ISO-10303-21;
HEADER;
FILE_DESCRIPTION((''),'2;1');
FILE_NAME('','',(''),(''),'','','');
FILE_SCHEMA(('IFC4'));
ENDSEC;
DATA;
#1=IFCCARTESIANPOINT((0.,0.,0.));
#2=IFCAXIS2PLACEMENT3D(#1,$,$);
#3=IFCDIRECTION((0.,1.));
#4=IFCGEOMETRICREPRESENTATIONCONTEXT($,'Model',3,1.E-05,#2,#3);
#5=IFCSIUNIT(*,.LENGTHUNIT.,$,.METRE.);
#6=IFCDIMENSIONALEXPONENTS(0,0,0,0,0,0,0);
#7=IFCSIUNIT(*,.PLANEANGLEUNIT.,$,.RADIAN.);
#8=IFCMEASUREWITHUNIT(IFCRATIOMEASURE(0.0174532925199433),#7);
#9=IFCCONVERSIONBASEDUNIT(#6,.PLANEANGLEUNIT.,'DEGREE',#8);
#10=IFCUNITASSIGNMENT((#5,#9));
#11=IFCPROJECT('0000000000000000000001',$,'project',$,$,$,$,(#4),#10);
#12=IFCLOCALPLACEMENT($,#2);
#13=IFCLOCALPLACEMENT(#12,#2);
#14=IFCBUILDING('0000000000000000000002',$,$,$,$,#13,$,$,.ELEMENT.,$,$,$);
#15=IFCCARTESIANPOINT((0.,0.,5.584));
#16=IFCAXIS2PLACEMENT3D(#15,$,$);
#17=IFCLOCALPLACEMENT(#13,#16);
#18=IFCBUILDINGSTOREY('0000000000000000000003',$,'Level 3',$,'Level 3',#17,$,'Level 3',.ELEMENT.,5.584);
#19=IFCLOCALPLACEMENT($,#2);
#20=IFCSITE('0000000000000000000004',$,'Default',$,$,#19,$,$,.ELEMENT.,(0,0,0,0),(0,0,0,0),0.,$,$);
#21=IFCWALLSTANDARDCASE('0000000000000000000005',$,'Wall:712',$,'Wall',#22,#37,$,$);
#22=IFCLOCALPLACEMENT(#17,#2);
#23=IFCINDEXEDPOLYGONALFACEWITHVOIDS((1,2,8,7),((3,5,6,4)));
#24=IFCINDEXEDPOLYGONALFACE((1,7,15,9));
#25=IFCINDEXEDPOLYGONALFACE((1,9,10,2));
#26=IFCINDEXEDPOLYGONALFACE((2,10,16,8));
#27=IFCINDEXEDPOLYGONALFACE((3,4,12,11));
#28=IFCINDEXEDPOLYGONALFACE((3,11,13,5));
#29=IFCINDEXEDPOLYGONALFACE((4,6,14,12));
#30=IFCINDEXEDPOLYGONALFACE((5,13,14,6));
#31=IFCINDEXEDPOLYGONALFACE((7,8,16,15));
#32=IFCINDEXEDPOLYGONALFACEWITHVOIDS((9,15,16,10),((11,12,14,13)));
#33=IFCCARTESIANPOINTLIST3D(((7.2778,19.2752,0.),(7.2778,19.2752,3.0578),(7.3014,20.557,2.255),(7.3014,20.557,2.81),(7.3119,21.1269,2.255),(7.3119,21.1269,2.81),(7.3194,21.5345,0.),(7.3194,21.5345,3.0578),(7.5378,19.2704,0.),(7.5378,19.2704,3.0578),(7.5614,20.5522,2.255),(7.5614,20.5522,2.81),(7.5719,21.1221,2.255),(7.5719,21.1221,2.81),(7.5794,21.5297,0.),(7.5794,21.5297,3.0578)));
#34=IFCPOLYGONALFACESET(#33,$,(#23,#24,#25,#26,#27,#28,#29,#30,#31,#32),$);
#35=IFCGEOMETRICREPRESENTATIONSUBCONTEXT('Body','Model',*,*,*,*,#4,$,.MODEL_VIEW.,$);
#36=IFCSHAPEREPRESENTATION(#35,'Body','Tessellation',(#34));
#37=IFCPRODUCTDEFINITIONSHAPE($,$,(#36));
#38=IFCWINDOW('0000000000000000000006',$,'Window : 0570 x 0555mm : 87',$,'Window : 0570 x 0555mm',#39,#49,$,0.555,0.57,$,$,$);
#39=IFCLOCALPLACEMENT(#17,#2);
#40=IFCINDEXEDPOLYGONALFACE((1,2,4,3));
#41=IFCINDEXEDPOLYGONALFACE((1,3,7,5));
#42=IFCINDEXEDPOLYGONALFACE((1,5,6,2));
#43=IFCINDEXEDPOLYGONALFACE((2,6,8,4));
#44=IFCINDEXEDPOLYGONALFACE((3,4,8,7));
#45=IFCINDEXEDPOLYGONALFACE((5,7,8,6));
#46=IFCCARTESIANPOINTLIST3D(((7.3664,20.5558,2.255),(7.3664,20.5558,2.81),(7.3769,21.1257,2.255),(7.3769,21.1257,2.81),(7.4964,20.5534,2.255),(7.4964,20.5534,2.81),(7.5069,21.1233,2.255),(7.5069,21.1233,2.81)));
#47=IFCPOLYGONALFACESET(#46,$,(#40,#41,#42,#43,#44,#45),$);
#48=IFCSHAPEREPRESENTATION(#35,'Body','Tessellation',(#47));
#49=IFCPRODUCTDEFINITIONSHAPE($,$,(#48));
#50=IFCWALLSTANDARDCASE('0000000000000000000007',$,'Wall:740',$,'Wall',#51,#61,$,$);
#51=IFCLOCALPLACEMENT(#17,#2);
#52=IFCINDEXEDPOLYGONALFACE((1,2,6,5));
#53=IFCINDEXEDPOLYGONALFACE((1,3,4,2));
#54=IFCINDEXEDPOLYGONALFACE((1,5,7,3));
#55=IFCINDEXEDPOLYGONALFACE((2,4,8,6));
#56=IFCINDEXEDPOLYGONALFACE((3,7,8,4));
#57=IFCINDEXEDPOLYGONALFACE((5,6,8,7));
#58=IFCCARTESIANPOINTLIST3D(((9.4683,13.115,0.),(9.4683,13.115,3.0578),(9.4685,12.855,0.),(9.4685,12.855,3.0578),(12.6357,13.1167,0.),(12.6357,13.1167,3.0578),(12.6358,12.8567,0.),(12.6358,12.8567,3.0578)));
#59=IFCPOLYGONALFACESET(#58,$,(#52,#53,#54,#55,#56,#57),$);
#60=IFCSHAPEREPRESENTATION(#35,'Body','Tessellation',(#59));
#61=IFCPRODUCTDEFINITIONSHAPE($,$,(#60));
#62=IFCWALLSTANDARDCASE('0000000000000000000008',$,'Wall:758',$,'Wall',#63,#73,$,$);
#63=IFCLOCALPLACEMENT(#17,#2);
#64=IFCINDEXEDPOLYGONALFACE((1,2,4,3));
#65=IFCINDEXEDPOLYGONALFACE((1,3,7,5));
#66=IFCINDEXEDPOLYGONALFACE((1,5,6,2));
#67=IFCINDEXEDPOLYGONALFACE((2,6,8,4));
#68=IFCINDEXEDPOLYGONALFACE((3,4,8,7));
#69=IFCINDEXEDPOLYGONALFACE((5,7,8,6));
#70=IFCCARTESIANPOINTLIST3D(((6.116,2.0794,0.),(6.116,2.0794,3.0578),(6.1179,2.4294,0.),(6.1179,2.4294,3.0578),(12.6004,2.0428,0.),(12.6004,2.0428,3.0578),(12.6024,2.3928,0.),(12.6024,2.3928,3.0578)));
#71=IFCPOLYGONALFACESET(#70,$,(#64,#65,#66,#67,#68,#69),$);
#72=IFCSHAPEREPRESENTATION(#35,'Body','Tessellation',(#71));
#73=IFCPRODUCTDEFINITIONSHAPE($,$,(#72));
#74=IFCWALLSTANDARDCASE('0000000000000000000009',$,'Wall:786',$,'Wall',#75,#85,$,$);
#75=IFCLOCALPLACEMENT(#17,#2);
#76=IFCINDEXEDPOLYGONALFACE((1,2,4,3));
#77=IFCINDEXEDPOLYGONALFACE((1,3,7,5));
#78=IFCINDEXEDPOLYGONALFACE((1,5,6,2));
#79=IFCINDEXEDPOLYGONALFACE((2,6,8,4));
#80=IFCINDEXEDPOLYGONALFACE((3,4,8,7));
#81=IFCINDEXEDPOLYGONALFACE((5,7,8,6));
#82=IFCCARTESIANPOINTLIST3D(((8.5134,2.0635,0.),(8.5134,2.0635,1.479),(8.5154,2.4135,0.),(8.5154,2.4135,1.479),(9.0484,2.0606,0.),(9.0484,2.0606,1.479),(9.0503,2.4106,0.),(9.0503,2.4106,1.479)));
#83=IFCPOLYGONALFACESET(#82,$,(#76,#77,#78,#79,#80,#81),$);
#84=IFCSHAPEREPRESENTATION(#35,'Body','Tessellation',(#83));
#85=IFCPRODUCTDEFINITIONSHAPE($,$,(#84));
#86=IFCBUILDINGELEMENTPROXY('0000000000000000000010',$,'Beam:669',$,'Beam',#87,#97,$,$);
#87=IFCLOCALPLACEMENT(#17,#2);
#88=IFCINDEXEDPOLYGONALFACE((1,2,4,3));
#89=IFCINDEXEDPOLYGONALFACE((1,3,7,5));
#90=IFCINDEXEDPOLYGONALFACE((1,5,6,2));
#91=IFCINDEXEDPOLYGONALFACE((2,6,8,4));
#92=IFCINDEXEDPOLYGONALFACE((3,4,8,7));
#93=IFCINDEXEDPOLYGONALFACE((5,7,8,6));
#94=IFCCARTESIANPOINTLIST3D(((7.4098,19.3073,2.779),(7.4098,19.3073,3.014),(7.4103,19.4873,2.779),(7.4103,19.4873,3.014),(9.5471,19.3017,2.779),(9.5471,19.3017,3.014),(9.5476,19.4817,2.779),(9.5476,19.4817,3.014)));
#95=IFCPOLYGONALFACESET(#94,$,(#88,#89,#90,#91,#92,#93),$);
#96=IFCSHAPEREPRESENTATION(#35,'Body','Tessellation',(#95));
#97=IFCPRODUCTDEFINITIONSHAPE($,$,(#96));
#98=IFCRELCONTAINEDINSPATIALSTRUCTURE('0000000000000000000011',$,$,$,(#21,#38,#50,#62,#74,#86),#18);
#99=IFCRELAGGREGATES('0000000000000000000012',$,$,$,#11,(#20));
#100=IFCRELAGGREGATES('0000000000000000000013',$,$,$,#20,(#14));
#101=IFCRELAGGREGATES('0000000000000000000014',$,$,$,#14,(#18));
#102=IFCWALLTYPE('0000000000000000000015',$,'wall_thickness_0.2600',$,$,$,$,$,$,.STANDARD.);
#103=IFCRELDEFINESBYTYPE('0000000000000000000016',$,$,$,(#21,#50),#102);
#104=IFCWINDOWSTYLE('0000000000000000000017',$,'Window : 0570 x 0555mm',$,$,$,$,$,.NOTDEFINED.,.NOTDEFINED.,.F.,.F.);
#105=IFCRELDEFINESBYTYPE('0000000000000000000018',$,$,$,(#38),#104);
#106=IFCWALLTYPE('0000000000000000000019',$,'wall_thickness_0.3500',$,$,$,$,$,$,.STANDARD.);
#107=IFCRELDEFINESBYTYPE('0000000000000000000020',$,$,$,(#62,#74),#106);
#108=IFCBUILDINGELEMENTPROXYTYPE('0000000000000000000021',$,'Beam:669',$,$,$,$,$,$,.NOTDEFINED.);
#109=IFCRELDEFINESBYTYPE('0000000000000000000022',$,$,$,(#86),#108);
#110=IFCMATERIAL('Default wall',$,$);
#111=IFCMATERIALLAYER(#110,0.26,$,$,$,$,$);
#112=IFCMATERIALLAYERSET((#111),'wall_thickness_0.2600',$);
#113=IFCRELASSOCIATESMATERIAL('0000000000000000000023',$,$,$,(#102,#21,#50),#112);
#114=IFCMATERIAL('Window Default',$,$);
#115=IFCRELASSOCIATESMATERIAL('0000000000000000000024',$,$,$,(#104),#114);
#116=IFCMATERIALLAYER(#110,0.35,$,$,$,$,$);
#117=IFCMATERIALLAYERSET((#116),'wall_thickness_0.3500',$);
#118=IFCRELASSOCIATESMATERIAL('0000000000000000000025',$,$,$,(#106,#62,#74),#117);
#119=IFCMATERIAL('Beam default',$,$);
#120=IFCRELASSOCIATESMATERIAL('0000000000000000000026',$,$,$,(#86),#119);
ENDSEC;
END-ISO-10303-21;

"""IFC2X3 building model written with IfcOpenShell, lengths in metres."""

from ifc_helpers import new_model, entity, si_unit, converted_unit, direction, frame, frame_2d, origin, origin_2d_with_axis, place, context, subcontext, project, spatial, polyline, rectangle, outline, extrude, source, transform, mapped, material, layer, layer_set, layer_usage, type_object, type_shapes, element, fill, save


model = new_model("IFC2X3")

# Units and contexts
model_context = context("Model", 3, precision=1e-05, world=origin(), true_north=direction((0.0, 1.0)))
body_context = subcontext(model_context, "Body", "Model", "MODEL_VIEW")
ifc_project = project(units=[si_unit("LENGTHUNIT", "METRE"), converted_unit("PLANEANGLEUNIT", "DEGREE", entity("IfcRatioMeasure", 0.0174532925199433), si_unit("PLANEANGLEUNIT", "RADIAN"), dimensions=[0, 0, 0, 0, 0, 0, 0])], contexts=[model_context])

# Site, building, storey
site_placement = place(None, origin())
site = spatial("IfcSite", under=ifc_project, at=site_placement, Name="Default", CompositionType="ELEMENT", RefLatitude=(0, 0, 0, 0), RefLongitude=(0, 0, 0, 0), RefElevation=0.0)
placement_1 = place(None, origin())
building_placement = place(placement_1, origin())
building = spatial("IfcBuilding", under=site, at=building_placement, CompositionType="ELEMENT")
storey_placement = place(building_placement, frame((0.0, 0.0, 5.584)))
storey = spatial("IfcBuildingStorey", under=building, at=storey_placement, Name="Level 3", ObjectType="Level 3", LongName="Level 3", CompositionType="ELEMENT", Elevation=5.584)

# Shared definitions
ifc_material_1 = material(Name="Default wall")

# Shared definitions
ifc_layer_1 = layer(ifc_material_1, 0.26)
ifc_layer_set_1 = layer_set([ifc_layer_1], Name="wall_thickness_0.2600")
ifc_layer_usage_1 = layer_usage(ifc_layer_set_1, "AXIS2", "POSITIVE", -0.13)
wall_type_1 = type_object("IfcWallType", Name="wall_thickness_0.2600", PredefinedType="STANDARD", material=ifc_layer_set_1)

# Wall, opening, window
wall_1_placement = place(storey_placement, frame((7.4494, 21.5321, 0.0), z_axis=(0.0, 0.0, 1.0), x_axis=(-0.018413, -0.99983, 0.0)))
wall_1 = element("IfcWallStandardCase", 1, at=wall_1_placement, inside=storey, type_object=wall_type_1, material=ifc_layer_usage_1, Name="Wall:712", ObjectType="Wall", context=body_context, shape_type="SweptSolid", body=[
    extrude(outline(polyline([(2.2597, -0.13), (2.2597, 0.13), (0.0, 0.13), (0.0, -0.13), (2.2597, -0.13)])), origin(), (0.0, 0.0, 1.0), 3.0578),
])
opening_1_placement = place(wall_1_placement, frame((0.4077, -0.13, 2.255)))
opening_1 = element("IfcOpeningElement", 2, at=opening_1_placement, cuts=wall_1, ObjectType="Opening", context=body_context, shape_type="SweptSolid", body=[
    extrude(rectangle(XDim=0.57, YDim=0.555, at=frame_2d((0.2775, 0.285), x_axis=(0.0, 1.0))), frame((0.0, 0.0, 0.0), z_axis=(0.0, 1.0, 0.0), x_axis=(0.0, 0.0, 1.0)), (0.0, 0.0, 1.0), 0.26),
])
ifc_material_2 = material(Name="Window Default")
window_style = type_object("IfcWindowStyle", Name="Window : 0570 x 0555mm", ConstructionType="NOTDEFINED", OperationType="NOTDEFINED", ParameterTakesPrecedence=False, Sizeable=False, material=ifc_material_2)
shared_shape_1 = source(origin(), body_context, "Body", "SweptSolid", [
    extrude(rectangle(XDim=0.13, YDim=0.57, at=origin_2d_with_axis()), frame((0.285, 0.13, 0.0), z_axis=(0.0, 0.0, 1.0), x_axis=(0.0, 1.0, 0.0)), (0.0, 0.0, 1.0), 0.555),
])
type_shapes(window_style, [shared_shape_1])
window_placement = place(opening_1_placement, origin())
window = element("IfcWindow", 3, at=window_placement, inside=storey, type_object=window_style, Name="Window : 0570 x 0555mm : 87", ObjectType="Window : 0570 x 0555mm", OverallHeight=0.555, OverallWidth=0.57, context=body_context, shape_type="MappedRepresentation", body=[
    mapped(shared_shape_1, transform((0.0, 0.0, 0.0), scale=1.0)),
])
fill(opening_1, window)

# Walls
wall_2_placement = place(storey_placement, frame((9.4684, 12.985, 0.0), z_axis=(0.0, 0.0, 1.0), x_axis=(1.0, 0.000546, 0.0)))
element("IfcWallStandardCase", 4, at=wall_2_placement, inside=storey, type_object=wall_type_1, material=ifc_layer_usage_1, Name="Wall:740", ObjectType="Wall", context=body_context, shape_type="SweptSolid", body=[
    extrude(outline(polyline([(3.1673, -0.13), (3.1673, 0.13), (0.0, 0.13), (0.0, -0.13), (3.1673, -0.13)])), origin(), (0.0, 0.0, 1.0), 3.0578),
])
ifc_layer_2 = layer(ifc_material_1, 0.35)
ifc_layer_set_2 = layer_set([ifc_layer_2], Name="wall_thickness_0.3500")
ifc_layer_usage_2 = layer_usage(ifc_layer_set_2, "AXIS2", "POSITIVE", -0.175)
wall_type_2 = type_object("IfcWallType", Name="wall_thickness_0.3500", PredefinedType="STANDARD", material=ifc_layer_set_2)
wall_3_placement = place(storey_placement, frame((6.117, 2.2544, 0.0), z_axis=(0.0, 0.0, 1.0), x_axis=(0.999984, -0.005634, 0.0)))
element("IfcWallStandardCase", 5, at=wall_3_placement, inside=storey, type_object=wall_type_2, material=ifc_layer_usage_2, Name="Wall:758", ObjectType="Wall", context=body_context, shape_type="SweptSolid", body=[
    extrude(outline(polyline([(6.4846, -0.175), (6.4846, 0.175), (0.0, 0.175), (0.0, -0.175), (6.4846, -0.175)])), origin(), (0.0, 0.0, 1.0), 3.0578),
])
wall_4_placement = place(storey_placement, frame((8.5144, 2.2385, 0.0), z_axis=(0.0, 0.0, 1.0), x_axis=(0.999985, -0.005496, 0.0)))
element("IfcWallStandardCase", 6, at=wall_4_placement, inside=storey, type_object=wall_type_2, material=ifc_layer_usage_2, Name="Wall:786", ObjectType="Wall", context=body_context, shape_type="SweptSolid", body=[
    extrude(outline(polyline([(0.535, -0.175), (0.535, 0.175), (0.0, 0.175), (0.0, -0.175), (0.535, -0.175)])), origin(), (0.0, 0.0, 1.0), 1.479),
])

# Building element proxy
ifc_material_3 = material(Name="Beam default")
building_element_proxy_type = type_object("IfcBuildingElementProxyType", Name="Beam:669", PredefinedType="NOTDEFINED")
shared_shape_2 = source(origin(), body_context, "Body", "SweptSolid", [
    extrude(outline(polyline([(2.1373, -0.09), (2.1373, 0.09), (0.0, 0.09), (0.0, -0.09), (2.1373, -0.09)])), origin(), (0.0, 0.0, 1.0), 0.235),
])
type_shapes(building_element_proxy_type, [shared_shape_2])
placement_2 = place(building_placement, frame((0.0, 0.0, 8.363)))
proxy_placement = place(placement_2, frame((7.4101, 19.3973, 0.0), z_axis=(0.0, 0.0, 1.0), x_axis=(0.999996, -0.002646, 0.0)))
element("IfcBuildingElementProxy", 7, at=proxy_placement, inside=storey, type_object=building_element_proxy_type, material=ifc_material_3, Name="Beam:669", ObjectType="Beam", context=body_context, shape_type="MappedRepresentation", body=[
    mapped(shared_shape_2, transform((0.0, 0.0, 0.0), scale=1.0)),
])

save(model, "model.ifc")
